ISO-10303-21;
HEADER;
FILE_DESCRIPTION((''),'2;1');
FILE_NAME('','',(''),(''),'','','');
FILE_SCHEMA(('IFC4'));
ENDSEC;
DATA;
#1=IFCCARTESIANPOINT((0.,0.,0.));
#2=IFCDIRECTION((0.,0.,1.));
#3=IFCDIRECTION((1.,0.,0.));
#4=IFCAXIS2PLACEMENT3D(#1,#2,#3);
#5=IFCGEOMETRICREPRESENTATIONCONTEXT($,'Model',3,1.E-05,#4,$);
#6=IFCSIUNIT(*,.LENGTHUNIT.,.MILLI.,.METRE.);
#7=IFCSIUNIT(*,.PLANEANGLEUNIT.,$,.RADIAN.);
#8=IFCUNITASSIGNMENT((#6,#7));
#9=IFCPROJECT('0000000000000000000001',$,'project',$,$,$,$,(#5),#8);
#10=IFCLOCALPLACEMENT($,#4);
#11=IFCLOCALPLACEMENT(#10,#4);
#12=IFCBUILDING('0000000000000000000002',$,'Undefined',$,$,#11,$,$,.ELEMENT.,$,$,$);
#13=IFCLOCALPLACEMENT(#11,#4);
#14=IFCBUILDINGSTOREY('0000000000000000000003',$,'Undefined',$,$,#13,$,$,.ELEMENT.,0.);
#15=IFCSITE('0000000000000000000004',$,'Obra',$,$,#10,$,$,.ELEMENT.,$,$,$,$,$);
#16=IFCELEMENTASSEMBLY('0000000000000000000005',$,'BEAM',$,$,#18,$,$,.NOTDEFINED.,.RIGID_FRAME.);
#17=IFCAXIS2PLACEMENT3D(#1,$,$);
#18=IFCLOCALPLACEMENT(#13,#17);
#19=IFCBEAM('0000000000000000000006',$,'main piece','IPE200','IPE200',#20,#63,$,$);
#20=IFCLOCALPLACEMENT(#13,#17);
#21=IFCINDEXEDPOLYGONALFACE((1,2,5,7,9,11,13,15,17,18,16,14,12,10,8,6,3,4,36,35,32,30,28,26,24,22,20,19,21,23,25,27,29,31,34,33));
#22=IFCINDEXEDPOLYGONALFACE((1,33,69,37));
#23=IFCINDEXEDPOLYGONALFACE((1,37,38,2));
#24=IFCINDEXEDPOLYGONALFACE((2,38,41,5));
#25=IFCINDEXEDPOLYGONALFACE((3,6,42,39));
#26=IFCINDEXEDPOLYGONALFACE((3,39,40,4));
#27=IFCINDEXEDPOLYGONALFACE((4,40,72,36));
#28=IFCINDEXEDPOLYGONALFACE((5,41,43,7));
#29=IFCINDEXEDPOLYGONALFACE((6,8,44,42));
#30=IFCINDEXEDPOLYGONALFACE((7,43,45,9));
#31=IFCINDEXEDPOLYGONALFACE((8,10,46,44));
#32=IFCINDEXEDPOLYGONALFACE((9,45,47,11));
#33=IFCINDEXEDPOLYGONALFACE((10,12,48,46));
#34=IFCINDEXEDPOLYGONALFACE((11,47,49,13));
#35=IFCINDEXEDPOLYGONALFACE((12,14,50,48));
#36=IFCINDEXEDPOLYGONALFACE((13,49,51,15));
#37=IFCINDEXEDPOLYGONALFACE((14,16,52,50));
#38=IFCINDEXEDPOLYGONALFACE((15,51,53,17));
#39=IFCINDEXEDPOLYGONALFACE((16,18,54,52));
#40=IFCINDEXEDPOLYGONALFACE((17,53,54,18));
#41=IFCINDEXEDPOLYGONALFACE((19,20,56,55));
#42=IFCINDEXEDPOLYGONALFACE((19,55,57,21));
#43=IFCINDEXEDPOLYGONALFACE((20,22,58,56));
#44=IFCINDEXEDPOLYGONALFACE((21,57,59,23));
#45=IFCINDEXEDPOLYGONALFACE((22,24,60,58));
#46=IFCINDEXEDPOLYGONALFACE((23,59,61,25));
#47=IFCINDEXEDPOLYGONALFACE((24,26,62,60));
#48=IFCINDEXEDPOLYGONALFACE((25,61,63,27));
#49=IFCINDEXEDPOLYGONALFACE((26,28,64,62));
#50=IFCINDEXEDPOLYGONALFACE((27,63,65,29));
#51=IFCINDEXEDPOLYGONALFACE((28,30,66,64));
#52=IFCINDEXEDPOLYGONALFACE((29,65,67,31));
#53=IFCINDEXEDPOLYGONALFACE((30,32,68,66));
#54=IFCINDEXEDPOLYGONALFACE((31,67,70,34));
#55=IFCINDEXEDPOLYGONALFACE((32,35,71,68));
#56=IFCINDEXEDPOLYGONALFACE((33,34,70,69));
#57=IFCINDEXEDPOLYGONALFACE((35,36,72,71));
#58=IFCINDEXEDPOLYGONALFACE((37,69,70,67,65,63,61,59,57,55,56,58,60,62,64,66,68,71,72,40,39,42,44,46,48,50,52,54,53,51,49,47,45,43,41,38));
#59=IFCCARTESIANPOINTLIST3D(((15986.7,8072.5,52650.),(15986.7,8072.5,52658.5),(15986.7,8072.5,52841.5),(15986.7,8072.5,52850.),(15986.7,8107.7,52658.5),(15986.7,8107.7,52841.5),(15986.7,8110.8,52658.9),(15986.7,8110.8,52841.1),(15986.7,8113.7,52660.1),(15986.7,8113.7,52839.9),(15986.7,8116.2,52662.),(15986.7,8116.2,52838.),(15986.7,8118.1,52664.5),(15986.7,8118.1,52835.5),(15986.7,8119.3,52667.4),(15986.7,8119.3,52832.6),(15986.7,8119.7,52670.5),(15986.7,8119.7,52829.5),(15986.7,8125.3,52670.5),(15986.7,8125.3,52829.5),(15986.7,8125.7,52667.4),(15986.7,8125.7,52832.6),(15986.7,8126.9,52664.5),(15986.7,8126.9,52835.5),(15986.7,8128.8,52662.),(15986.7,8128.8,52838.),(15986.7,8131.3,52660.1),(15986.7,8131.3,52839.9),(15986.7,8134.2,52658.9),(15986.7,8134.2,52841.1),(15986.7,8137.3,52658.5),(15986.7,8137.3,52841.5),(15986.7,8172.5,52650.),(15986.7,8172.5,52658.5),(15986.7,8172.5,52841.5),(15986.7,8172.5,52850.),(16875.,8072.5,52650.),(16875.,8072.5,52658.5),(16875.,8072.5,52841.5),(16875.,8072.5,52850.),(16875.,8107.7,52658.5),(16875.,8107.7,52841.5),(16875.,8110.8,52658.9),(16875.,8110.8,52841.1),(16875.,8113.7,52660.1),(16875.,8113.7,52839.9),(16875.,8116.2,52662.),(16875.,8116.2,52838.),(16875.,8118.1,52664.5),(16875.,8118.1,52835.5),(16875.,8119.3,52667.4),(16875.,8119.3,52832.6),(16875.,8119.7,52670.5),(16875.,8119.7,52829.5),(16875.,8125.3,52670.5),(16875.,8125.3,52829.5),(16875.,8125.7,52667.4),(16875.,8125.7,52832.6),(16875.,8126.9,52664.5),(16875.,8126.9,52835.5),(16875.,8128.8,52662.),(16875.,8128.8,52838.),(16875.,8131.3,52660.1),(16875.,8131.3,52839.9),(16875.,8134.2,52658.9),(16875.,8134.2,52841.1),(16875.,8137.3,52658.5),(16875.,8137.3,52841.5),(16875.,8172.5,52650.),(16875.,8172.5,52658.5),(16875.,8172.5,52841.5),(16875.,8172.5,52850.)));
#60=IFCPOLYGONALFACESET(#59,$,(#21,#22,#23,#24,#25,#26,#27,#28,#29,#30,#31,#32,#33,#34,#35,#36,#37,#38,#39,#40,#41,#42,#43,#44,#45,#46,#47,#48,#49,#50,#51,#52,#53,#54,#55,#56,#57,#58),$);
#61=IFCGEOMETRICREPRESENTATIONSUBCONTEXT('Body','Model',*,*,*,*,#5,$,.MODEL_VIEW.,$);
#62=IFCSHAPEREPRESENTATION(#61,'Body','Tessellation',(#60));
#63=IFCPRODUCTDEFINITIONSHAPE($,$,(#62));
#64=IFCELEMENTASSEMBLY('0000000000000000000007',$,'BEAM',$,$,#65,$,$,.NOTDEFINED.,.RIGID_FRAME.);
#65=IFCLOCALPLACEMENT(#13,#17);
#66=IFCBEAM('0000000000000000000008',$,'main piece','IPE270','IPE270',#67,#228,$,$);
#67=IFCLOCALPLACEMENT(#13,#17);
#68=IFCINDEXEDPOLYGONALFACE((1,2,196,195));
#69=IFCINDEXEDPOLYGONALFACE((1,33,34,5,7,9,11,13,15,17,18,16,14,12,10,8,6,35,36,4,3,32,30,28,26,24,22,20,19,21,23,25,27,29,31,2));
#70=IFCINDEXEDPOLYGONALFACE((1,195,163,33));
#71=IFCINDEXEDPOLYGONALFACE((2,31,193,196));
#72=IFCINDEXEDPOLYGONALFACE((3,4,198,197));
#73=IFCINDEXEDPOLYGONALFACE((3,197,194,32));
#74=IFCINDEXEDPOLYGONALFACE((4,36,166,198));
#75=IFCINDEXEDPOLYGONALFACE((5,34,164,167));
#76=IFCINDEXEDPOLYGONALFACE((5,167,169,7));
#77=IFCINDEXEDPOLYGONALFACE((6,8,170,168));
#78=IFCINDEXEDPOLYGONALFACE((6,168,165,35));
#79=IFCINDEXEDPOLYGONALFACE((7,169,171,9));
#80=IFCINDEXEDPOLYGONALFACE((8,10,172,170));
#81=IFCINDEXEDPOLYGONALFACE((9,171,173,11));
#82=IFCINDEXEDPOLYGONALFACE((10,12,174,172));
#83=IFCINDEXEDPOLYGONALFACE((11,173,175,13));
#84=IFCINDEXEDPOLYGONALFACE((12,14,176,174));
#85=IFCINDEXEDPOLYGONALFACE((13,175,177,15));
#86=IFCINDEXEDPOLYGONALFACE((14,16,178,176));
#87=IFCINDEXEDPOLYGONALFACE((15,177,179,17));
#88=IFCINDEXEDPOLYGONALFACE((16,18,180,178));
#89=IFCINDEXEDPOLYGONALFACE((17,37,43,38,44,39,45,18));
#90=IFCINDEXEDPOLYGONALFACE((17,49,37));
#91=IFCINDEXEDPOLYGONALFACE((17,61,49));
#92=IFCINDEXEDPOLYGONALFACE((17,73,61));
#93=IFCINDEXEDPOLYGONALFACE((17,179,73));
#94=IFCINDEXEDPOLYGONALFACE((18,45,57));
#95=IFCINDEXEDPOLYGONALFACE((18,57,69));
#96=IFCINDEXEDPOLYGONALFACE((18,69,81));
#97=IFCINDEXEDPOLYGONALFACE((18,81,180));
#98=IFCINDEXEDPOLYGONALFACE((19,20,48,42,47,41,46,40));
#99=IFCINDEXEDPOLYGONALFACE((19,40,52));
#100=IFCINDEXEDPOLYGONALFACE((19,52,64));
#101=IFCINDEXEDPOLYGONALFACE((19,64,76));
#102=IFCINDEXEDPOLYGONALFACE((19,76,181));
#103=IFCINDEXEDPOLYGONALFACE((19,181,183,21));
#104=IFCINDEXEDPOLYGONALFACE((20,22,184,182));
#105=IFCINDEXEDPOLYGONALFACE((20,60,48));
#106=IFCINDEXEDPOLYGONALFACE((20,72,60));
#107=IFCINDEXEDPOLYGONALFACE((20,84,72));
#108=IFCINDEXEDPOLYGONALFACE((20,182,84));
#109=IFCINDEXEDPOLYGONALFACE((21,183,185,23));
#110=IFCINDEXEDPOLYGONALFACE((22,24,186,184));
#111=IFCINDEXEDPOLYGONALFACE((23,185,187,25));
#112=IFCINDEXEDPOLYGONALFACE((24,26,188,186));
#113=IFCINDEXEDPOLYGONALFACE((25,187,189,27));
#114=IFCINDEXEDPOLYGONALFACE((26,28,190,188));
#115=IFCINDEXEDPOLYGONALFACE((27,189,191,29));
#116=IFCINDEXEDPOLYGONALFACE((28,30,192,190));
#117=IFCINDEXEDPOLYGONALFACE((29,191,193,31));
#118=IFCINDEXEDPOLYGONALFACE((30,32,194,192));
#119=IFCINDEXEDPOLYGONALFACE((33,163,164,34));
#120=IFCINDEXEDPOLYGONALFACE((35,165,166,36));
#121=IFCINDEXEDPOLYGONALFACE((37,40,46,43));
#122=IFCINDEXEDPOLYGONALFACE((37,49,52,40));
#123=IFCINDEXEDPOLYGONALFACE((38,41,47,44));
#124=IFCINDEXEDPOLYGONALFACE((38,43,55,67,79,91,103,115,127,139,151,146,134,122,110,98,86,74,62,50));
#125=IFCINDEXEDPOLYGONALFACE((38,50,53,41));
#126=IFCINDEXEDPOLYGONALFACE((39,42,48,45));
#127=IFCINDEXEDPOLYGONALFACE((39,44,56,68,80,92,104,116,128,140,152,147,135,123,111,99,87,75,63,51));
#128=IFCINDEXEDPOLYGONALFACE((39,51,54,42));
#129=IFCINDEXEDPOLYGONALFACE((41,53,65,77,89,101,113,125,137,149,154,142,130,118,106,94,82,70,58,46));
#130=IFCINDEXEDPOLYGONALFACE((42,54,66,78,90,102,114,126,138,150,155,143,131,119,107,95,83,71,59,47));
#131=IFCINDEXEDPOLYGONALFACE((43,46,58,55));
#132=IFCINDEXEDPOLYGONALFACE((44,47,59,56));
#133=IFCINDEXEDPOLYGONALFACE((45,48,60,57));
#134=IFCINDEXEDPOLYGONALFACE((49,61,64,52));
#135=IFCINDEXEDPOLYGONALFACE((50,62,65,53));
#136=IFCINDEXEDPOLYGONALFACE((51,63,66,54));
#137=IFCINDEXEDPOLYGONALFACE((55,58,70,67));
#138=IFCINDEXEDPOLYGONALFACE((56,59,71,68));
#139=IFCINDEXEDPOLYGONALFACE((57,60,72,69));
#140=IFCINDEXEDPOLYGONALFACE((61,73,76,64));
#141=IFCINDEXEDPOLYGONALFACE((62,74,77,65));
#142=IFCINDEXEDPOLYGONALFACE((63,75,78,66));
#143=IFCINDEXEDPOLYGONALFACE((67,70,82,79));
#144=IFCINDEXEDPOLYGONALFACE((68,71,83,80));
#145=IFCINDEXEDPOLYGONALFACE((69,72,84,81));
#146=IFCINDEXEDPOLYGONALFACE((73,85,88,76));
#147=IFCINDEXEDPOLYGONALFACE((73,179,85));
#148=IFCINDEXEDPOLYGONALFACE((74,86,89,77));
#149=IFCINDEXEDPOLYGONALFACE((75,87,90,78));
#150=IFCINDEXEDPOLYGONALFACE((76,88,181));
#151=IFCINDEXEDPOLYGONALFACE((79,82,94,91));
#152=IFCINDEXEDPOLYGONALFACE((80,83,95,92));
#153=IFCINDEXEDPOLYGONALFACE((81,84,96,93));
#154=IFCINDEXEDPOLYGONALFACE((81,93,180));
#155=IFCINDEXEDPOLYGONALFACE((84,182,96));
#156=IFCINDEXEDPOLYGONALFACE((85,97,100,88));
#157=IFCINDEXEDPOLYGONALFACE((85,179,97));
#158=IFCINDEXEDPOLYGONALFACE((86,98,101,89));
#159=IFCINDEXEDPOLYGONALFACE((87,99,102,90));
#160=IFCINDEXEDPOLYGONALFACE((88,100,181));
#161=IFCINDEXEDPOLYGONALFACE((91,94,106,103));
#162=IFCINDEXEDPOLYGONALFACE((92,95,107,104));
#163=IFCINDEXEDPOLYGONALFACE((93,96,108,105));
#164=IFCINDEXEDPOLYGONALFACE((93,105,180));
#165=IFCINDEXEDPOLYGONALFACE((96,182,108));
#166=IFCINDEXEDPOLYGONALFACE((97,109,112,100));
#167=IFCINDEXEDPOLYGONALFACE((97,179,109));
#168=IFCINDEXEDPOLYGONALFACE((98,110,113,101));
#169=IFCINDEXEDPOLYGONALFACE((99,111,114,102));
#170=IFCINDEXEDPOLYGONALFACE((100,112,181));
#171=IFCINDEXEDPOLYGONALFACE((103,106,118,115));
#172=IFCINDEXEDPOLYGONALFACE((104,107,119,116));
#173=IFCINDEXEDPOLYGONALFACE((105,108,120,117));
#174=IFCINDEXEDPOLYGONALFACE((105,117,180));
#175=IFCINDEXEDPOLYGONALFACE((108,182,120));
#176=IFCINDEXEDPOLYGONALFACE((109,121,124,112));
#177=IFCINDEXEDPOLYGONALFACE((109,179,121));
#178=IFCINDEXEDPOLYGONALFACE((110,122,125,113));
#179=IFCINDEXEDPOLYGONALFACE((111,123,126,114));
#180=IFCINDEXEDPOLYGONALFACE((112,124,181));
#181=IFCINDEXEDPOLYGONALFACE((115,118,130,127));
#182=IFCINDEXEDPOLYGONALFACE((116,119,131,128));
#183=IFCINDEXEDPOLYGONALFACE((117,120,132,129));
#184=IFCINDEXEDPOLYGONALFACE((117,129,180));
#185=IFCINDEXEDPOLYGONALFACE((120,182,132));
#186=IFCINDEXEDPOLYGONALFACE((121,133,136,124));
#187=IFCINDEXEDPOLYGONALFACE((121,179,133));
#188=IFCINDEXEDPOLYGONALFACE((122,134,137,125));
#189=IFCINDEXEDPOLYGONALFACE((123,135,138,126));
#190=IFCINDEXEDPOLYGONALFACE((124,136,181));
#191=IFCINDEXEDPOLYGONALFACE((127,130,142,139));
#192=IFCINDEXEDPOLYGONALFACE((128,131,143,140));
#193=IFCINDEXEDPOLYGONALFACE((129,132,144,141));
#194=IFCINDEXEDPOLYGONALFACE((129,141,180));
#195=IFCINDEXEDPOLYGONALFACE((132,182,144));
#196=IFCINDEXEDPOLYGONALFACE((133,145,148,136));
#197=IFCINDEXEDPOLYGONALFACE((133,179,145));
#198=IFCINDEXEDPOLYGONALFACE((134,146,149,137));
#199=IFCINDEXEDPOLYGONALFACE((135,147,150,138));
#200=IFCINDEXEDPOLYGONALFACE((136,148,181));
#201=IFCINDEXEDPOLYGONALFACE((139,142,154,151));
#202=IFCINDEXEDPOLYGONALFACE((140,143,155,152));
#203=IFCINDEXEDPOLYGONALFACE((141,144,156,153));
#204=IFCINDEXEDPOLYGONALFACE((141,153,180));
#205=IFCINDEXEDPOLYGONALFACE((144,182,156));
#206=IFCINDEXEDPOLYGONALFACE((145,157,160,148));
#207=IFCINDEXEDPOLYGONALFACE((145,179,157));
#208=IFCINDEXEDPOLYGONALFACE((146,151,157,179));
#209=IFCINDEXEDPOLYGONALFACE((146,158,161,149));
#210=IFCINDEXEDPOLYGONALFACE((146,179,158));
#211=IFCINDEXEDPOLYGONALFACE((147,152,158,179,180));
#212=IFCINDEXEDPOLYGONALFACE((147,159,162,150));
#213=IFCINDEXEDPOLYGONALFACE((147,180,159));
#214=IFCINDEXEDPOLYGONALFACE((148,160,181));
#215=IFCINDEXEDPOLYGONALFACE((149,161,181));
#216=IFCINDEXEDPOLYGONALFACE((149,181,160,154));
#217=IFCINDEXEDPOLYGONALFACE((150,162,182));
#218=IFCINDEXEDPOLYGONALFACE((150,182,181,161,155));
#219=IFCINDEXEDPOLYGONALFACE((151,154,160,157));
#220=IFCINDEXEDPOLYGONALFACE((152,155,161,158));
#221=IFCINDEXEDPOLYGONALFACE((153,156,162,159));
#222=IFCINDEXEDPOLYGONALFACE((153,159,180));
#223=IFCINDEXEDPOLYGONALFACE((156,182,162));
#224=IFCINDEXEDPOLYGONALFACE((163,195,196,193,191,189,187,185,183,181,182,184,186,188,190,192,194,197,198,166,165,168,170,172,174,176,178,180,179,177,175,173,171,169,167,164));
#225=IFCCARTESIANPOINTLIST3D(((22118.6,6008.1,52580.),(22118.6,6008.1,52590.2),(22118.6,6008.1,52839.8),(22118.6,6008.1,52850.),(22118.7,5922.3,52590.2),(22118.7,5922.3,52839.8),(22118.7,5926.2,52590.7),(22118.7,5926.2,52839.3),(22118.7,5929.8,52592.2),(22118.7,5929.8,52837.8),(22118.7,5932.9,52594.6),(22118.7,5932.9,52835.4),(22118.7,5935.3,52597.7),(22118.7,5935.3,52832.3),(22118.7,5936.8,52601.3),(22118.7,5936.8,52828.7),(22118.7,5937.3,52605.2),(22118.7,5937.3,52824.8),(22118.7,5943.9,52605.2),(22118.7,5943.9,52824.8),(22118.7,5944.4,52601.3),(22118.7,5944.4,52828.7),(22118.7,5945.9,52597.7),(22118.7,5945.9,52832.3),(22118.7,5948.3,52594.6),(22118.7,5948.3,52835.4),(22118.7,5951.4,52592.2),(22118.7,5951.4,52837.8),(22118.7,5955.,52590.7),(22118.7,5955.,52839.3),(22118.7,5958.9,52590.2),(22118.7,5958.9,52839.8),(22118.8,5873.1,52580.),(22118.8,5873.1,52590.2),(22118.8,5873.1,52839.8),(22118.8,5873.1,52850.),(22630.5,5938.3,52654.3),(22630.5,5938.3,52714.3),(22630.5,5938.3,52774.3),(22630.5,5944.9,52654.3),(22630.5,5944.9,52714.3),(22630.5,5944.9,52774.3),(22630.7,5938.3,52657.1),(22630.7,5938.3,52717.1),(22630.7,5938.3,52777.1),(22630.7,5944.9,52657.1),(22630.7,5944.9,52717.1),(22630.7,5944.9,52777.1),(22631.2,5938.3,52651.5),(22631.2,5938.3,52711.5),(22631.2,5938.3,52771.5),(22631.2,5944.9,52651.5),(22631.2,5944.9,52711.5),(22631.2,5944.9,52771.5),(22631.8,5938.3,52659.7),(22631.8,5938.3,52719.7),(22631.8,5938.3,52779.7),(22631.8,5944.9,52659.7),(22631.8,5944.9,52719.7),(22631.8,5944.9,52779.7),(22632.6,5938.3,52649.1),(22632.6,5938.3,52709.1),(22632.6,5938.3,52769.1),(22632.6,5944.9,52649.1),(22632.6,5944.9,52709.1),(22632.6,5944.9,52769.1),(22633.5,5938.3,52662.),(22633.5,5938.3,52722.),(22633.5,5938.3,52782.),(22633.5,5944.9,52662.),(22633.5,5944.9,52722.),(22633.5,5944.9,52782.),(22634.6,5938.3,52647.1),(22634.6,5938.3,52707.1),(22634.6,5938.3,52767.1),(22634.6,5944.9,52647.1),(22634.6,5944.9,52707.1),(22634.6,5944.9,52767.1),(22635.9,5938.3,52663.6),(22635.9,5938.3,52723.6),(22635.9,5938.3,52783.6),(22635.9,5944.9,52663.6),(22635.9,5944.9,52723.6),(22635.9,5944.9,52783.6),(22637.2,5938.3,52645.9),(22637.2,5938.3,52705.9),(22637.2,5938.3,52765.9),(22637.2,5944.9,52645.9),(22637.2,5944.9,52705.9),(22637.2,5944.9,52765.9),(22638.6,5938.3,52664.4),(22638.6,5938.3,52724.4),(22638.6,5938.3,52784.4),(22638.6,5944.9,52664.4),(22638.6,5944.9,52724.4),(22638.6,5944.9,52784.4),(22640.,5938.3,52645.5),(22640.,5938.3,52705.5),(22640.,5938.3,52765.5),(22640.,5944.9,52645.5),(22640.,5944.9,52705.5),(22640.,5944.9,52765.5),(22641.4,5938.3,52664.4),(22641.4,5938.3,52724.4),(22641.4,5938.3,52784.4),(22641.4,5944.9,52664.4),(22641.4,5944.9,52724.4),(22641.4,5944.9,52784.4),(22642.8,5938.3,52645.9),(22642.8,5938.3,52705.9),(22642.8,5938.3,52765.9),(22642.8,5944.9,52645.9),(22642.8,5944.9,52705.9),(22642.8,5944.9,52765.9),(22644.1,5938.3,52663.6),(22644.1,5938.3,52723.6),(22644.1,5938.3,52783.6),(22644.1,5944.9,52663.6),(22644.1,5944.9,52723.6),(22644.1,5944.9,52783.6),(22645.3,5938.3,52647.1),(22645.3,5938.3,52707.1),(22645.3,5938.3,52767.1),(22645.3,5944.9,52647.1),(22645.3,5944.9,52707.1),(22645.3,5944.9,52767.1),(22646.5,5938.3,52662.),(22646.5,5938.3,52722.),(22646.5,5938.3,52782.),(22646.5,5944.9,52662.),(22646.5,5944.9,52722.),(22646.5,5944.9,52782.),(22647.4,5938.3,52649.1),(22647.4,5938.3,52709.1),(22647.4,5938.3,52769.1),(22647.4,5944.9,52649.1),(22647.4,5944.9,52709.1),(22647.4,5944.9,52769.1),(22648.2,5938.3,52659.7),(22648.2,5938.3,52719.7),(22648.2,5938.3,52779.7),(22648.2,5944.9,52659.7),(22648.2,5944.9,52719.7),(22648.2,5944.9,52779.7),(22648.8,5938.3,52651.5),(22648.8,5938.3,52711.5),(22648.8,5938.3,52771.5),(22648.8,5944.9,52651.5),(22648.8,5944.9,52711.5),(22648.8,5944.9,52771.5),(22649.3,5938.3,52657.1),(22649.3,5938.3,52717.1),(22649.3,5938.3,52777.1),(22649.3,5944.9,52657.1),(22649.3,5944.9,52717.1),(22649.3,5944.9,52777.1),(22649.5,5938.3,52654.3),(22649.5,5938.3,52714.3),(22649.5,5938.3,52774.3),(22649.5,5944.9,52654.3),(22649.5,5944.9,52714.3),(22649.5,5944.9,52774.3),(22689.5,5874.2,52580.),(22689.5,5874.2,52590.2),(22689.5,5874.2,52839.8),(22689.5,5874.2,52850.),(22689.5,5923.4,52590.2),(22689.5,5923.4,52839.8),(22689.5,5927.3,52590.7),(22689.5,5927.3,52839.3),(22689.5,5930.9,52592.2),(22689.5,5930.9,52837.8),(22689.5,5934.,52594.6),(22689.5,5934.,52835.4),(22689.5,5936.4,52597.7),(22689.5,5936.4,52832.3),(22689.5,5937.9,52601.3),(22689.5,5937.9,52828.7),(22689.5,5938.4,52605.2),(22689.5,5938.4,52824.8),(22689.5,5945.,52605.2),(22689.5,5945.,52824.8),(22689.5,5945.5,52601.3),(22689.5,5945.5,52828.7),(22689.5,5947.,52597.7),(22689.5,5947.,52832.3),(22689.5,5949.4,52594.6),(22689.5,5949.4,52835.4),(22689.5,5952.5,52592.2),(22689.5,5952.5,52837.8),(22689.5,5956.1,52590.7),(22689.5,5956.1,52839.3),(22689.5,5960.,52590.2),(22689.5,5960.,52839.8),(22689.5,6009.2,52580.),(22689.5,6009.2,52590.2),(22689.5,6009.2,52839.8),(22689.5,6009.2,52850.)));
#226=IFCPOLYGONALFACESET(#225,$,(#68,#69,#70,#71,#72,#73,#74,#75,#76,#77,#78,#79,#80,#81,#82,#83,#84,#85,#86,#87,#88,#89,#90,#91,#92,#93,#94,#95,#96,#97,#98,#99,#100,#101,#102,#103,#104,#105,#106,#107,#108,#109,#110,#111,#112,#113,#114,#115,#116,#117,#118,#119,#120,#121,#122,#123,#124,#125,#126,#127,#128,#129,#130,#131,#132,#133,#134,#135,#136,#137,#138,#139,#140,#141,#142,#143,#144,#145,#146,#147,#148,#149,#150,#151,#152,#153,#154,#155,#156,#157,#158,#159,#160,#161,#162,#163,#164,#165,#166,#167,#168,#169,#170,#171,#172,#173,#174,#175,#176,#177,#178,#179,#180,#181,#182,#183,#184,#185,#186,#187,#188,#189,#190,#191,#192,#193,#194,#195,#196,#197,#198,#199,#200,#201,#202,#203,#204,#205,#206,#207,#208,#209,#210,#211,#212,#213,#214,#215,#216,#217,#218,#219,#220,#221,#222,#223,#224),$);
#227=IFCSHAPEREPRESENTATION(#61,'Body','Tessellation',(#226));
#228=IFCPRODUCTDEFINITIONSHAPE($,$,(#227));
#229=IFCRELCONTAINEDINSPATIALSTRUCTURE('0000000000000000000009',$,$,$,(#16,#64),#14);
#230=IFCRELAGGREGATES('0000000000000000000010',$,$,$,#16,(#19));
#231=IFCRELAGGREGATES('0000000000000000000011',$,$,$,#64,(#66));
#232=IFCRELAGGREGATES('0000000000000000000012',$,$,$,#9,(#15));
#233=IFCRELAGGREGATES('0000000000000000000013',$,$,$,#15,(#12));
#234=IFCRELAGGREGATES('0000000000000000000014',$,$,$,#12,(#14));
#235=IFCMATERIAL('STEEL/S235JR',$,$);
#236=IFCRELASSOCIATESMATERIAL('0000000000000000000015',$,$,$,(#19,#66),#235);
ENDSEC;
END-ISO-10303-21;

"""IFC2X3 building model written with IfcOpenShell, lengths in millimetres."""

from ifc_helpers import new_model, si_unit, frame, origin_with_axes, origin_2d_with_axis, place, context, subcontext, project, spatial, circle, i_section, extrude, clip, halfspace, source, transform, mapped, material, element, aggregate, save


model = new_model("IFC2X3")

# Units and contexts
model_context = context("Model", 3, precision=1e-05, world=origin_with_axes())
body_context = subcontext(model_context, "Body", "Model", "MODEL_VIEW")
ifc_project = project(units=[si_unit("LENGTHUNIT", "METRE", prefix="MILLI"), si_unit("PLANEANGLEUNIT", "RADIAN")], contexts=[model_context])

# Site, building, storey
site_placement = place(None, origin_with_axes())
site = spatial("IfcSite", under=ifc_project, at=site_placement, Name="Obra", CompositionType="ELEMENT")
building_placement = place(site_placement, origin_with_axes())
building = spatial("IfcBuilding", under=site, at=building_placement, Name="Undefined", CompositionType="ELEMENT")
storey_placement = place(building_placement, origin_with_axes())
storey = spatial("IfcBuildingStorey", under=building, at=storey_placement, Name="Undefined", CompositionType="ELEMENT", Elevation=0.0)

# Shared definitions
ifc_material_1 = material(Name="STEEL/S235JR")

# Element assembly, beam
assembly_1_placement = place(storey_placement, origin_with_axes())
assembly_1 = element("IfcElementAssembly", 1, at=assembly_1_placement, inside=storey, Name="BEAM", AssemblyPlace="NOTDEFINED", PredefinedType="RIGID_FRAME")
beam_1_placement = place(assembly_1_placement, frame((15986.7, 8122.5, 52750.0), z_axis=(0.0, 0.0, 1.0), x_axis=(1.0, 0.0, 0.0)))
beam_1 = element("IfcBeam", 2, at=beam_1_placement, material=ifc_material_1, Name="main piece", Description="IPE200", ObjectType="IPE200", context=body_context, shape_type="SweptSolid", body=[
    extrude(i_section(OverallWidth=100.0, OverallDepth=200.0, WebThickness=5.6, FlangeThickness=8.5, FilletRadius=12.0, at=origin_2d_with_axis()), frame((888.3, 0.0, 0.0), z_axis=(-1.0, 0.0, 0.0), x_axis=(0.0, -1.0, 0.0)), (0.0, 0.0, 1.0), 888.3),
])
aggregate(assembly_1, [beam_1])

# Element assembly, beam, opening
assembly_2_placement = place(storey_placement, origin_with_axes())
assembly_2 = element("IfcElementAssembly", 3, at=assembly_2_placement, inside=storey, Name="BEAM", AssemblyPlace="NOTDEFINED", PredefinedType="RIGID_FRAME")
beam_2_placement = place(assembly_2_placement, frame((23087.3, 5942.5, 52715.0), z_axis=(0.0, 0.0, 1.0), x_axis=(-0.999998, -0.00197, 0.0)))
beam_2 = element("IfcBeam", 4, at=beam_2_placement, material=ifc_material_1, Name="main piece", Description="IPE270", ObjectType="IPE270", context=body_context, shape_type="Clipping", body=[
    clip(extrude(i_section(OverallWidth=135.0, OverallDepth=270.0, WebThickness=6.6, FlangeThickness=10.2, FilletRadius=15.0, at=origin_2d_with_axis()), frame((968.7, 0.0, 0.0), z_axis=(-1.0, 0.0, 0.0), x_axis=(0.0, -1.0, 0.0)), (0.0, 0.0, 1.0), 968.7), halfspace(frame((397.9, 59.0, -120.0), z_axis=(-0.999998, 0.001952, 0.0), x_axis=(0.0, 0.0, 1.0)), False)),
])
shared_shape_1 = source(origin_with_axes(), body_context, "Body", "SweptSolid", [
    extrude(circle(Radius=9.5, at=origin_2d_with_axis()), frame((0.0, -2.3, 0.0), z_axis=(0.0, 1.0, 0.0), x_axis=(1.0, 0.0, 0.0)), (0.0, 0.0, 1.0), 6.8),
])
opening_1_placement = place(assembly_2_placement, frame((22690.0, 5942.7, 52835.0), z_axis=(-1.0, 0.0, 0.0), x_axis=(0.0, 0.0, -1.0)))
element("IfcOpeningElement", 5, at=opening_1_placement, cuts=beam_2, ObjectType="Opening", context=body_context, shape_type="MappedRepresentation", body=[
    mapped(shared_shape_1, transform((60.0, 0.0, 50.0))),
    mapped(shared_shape_1, transform((120.0, 0.0, 50.0))),
    mapped(shared_shape_1, transform((180.0, 0.0, 50.0))),
])

aggregate(assembly_2, [beam_2])

save(model, "model.ifc")
